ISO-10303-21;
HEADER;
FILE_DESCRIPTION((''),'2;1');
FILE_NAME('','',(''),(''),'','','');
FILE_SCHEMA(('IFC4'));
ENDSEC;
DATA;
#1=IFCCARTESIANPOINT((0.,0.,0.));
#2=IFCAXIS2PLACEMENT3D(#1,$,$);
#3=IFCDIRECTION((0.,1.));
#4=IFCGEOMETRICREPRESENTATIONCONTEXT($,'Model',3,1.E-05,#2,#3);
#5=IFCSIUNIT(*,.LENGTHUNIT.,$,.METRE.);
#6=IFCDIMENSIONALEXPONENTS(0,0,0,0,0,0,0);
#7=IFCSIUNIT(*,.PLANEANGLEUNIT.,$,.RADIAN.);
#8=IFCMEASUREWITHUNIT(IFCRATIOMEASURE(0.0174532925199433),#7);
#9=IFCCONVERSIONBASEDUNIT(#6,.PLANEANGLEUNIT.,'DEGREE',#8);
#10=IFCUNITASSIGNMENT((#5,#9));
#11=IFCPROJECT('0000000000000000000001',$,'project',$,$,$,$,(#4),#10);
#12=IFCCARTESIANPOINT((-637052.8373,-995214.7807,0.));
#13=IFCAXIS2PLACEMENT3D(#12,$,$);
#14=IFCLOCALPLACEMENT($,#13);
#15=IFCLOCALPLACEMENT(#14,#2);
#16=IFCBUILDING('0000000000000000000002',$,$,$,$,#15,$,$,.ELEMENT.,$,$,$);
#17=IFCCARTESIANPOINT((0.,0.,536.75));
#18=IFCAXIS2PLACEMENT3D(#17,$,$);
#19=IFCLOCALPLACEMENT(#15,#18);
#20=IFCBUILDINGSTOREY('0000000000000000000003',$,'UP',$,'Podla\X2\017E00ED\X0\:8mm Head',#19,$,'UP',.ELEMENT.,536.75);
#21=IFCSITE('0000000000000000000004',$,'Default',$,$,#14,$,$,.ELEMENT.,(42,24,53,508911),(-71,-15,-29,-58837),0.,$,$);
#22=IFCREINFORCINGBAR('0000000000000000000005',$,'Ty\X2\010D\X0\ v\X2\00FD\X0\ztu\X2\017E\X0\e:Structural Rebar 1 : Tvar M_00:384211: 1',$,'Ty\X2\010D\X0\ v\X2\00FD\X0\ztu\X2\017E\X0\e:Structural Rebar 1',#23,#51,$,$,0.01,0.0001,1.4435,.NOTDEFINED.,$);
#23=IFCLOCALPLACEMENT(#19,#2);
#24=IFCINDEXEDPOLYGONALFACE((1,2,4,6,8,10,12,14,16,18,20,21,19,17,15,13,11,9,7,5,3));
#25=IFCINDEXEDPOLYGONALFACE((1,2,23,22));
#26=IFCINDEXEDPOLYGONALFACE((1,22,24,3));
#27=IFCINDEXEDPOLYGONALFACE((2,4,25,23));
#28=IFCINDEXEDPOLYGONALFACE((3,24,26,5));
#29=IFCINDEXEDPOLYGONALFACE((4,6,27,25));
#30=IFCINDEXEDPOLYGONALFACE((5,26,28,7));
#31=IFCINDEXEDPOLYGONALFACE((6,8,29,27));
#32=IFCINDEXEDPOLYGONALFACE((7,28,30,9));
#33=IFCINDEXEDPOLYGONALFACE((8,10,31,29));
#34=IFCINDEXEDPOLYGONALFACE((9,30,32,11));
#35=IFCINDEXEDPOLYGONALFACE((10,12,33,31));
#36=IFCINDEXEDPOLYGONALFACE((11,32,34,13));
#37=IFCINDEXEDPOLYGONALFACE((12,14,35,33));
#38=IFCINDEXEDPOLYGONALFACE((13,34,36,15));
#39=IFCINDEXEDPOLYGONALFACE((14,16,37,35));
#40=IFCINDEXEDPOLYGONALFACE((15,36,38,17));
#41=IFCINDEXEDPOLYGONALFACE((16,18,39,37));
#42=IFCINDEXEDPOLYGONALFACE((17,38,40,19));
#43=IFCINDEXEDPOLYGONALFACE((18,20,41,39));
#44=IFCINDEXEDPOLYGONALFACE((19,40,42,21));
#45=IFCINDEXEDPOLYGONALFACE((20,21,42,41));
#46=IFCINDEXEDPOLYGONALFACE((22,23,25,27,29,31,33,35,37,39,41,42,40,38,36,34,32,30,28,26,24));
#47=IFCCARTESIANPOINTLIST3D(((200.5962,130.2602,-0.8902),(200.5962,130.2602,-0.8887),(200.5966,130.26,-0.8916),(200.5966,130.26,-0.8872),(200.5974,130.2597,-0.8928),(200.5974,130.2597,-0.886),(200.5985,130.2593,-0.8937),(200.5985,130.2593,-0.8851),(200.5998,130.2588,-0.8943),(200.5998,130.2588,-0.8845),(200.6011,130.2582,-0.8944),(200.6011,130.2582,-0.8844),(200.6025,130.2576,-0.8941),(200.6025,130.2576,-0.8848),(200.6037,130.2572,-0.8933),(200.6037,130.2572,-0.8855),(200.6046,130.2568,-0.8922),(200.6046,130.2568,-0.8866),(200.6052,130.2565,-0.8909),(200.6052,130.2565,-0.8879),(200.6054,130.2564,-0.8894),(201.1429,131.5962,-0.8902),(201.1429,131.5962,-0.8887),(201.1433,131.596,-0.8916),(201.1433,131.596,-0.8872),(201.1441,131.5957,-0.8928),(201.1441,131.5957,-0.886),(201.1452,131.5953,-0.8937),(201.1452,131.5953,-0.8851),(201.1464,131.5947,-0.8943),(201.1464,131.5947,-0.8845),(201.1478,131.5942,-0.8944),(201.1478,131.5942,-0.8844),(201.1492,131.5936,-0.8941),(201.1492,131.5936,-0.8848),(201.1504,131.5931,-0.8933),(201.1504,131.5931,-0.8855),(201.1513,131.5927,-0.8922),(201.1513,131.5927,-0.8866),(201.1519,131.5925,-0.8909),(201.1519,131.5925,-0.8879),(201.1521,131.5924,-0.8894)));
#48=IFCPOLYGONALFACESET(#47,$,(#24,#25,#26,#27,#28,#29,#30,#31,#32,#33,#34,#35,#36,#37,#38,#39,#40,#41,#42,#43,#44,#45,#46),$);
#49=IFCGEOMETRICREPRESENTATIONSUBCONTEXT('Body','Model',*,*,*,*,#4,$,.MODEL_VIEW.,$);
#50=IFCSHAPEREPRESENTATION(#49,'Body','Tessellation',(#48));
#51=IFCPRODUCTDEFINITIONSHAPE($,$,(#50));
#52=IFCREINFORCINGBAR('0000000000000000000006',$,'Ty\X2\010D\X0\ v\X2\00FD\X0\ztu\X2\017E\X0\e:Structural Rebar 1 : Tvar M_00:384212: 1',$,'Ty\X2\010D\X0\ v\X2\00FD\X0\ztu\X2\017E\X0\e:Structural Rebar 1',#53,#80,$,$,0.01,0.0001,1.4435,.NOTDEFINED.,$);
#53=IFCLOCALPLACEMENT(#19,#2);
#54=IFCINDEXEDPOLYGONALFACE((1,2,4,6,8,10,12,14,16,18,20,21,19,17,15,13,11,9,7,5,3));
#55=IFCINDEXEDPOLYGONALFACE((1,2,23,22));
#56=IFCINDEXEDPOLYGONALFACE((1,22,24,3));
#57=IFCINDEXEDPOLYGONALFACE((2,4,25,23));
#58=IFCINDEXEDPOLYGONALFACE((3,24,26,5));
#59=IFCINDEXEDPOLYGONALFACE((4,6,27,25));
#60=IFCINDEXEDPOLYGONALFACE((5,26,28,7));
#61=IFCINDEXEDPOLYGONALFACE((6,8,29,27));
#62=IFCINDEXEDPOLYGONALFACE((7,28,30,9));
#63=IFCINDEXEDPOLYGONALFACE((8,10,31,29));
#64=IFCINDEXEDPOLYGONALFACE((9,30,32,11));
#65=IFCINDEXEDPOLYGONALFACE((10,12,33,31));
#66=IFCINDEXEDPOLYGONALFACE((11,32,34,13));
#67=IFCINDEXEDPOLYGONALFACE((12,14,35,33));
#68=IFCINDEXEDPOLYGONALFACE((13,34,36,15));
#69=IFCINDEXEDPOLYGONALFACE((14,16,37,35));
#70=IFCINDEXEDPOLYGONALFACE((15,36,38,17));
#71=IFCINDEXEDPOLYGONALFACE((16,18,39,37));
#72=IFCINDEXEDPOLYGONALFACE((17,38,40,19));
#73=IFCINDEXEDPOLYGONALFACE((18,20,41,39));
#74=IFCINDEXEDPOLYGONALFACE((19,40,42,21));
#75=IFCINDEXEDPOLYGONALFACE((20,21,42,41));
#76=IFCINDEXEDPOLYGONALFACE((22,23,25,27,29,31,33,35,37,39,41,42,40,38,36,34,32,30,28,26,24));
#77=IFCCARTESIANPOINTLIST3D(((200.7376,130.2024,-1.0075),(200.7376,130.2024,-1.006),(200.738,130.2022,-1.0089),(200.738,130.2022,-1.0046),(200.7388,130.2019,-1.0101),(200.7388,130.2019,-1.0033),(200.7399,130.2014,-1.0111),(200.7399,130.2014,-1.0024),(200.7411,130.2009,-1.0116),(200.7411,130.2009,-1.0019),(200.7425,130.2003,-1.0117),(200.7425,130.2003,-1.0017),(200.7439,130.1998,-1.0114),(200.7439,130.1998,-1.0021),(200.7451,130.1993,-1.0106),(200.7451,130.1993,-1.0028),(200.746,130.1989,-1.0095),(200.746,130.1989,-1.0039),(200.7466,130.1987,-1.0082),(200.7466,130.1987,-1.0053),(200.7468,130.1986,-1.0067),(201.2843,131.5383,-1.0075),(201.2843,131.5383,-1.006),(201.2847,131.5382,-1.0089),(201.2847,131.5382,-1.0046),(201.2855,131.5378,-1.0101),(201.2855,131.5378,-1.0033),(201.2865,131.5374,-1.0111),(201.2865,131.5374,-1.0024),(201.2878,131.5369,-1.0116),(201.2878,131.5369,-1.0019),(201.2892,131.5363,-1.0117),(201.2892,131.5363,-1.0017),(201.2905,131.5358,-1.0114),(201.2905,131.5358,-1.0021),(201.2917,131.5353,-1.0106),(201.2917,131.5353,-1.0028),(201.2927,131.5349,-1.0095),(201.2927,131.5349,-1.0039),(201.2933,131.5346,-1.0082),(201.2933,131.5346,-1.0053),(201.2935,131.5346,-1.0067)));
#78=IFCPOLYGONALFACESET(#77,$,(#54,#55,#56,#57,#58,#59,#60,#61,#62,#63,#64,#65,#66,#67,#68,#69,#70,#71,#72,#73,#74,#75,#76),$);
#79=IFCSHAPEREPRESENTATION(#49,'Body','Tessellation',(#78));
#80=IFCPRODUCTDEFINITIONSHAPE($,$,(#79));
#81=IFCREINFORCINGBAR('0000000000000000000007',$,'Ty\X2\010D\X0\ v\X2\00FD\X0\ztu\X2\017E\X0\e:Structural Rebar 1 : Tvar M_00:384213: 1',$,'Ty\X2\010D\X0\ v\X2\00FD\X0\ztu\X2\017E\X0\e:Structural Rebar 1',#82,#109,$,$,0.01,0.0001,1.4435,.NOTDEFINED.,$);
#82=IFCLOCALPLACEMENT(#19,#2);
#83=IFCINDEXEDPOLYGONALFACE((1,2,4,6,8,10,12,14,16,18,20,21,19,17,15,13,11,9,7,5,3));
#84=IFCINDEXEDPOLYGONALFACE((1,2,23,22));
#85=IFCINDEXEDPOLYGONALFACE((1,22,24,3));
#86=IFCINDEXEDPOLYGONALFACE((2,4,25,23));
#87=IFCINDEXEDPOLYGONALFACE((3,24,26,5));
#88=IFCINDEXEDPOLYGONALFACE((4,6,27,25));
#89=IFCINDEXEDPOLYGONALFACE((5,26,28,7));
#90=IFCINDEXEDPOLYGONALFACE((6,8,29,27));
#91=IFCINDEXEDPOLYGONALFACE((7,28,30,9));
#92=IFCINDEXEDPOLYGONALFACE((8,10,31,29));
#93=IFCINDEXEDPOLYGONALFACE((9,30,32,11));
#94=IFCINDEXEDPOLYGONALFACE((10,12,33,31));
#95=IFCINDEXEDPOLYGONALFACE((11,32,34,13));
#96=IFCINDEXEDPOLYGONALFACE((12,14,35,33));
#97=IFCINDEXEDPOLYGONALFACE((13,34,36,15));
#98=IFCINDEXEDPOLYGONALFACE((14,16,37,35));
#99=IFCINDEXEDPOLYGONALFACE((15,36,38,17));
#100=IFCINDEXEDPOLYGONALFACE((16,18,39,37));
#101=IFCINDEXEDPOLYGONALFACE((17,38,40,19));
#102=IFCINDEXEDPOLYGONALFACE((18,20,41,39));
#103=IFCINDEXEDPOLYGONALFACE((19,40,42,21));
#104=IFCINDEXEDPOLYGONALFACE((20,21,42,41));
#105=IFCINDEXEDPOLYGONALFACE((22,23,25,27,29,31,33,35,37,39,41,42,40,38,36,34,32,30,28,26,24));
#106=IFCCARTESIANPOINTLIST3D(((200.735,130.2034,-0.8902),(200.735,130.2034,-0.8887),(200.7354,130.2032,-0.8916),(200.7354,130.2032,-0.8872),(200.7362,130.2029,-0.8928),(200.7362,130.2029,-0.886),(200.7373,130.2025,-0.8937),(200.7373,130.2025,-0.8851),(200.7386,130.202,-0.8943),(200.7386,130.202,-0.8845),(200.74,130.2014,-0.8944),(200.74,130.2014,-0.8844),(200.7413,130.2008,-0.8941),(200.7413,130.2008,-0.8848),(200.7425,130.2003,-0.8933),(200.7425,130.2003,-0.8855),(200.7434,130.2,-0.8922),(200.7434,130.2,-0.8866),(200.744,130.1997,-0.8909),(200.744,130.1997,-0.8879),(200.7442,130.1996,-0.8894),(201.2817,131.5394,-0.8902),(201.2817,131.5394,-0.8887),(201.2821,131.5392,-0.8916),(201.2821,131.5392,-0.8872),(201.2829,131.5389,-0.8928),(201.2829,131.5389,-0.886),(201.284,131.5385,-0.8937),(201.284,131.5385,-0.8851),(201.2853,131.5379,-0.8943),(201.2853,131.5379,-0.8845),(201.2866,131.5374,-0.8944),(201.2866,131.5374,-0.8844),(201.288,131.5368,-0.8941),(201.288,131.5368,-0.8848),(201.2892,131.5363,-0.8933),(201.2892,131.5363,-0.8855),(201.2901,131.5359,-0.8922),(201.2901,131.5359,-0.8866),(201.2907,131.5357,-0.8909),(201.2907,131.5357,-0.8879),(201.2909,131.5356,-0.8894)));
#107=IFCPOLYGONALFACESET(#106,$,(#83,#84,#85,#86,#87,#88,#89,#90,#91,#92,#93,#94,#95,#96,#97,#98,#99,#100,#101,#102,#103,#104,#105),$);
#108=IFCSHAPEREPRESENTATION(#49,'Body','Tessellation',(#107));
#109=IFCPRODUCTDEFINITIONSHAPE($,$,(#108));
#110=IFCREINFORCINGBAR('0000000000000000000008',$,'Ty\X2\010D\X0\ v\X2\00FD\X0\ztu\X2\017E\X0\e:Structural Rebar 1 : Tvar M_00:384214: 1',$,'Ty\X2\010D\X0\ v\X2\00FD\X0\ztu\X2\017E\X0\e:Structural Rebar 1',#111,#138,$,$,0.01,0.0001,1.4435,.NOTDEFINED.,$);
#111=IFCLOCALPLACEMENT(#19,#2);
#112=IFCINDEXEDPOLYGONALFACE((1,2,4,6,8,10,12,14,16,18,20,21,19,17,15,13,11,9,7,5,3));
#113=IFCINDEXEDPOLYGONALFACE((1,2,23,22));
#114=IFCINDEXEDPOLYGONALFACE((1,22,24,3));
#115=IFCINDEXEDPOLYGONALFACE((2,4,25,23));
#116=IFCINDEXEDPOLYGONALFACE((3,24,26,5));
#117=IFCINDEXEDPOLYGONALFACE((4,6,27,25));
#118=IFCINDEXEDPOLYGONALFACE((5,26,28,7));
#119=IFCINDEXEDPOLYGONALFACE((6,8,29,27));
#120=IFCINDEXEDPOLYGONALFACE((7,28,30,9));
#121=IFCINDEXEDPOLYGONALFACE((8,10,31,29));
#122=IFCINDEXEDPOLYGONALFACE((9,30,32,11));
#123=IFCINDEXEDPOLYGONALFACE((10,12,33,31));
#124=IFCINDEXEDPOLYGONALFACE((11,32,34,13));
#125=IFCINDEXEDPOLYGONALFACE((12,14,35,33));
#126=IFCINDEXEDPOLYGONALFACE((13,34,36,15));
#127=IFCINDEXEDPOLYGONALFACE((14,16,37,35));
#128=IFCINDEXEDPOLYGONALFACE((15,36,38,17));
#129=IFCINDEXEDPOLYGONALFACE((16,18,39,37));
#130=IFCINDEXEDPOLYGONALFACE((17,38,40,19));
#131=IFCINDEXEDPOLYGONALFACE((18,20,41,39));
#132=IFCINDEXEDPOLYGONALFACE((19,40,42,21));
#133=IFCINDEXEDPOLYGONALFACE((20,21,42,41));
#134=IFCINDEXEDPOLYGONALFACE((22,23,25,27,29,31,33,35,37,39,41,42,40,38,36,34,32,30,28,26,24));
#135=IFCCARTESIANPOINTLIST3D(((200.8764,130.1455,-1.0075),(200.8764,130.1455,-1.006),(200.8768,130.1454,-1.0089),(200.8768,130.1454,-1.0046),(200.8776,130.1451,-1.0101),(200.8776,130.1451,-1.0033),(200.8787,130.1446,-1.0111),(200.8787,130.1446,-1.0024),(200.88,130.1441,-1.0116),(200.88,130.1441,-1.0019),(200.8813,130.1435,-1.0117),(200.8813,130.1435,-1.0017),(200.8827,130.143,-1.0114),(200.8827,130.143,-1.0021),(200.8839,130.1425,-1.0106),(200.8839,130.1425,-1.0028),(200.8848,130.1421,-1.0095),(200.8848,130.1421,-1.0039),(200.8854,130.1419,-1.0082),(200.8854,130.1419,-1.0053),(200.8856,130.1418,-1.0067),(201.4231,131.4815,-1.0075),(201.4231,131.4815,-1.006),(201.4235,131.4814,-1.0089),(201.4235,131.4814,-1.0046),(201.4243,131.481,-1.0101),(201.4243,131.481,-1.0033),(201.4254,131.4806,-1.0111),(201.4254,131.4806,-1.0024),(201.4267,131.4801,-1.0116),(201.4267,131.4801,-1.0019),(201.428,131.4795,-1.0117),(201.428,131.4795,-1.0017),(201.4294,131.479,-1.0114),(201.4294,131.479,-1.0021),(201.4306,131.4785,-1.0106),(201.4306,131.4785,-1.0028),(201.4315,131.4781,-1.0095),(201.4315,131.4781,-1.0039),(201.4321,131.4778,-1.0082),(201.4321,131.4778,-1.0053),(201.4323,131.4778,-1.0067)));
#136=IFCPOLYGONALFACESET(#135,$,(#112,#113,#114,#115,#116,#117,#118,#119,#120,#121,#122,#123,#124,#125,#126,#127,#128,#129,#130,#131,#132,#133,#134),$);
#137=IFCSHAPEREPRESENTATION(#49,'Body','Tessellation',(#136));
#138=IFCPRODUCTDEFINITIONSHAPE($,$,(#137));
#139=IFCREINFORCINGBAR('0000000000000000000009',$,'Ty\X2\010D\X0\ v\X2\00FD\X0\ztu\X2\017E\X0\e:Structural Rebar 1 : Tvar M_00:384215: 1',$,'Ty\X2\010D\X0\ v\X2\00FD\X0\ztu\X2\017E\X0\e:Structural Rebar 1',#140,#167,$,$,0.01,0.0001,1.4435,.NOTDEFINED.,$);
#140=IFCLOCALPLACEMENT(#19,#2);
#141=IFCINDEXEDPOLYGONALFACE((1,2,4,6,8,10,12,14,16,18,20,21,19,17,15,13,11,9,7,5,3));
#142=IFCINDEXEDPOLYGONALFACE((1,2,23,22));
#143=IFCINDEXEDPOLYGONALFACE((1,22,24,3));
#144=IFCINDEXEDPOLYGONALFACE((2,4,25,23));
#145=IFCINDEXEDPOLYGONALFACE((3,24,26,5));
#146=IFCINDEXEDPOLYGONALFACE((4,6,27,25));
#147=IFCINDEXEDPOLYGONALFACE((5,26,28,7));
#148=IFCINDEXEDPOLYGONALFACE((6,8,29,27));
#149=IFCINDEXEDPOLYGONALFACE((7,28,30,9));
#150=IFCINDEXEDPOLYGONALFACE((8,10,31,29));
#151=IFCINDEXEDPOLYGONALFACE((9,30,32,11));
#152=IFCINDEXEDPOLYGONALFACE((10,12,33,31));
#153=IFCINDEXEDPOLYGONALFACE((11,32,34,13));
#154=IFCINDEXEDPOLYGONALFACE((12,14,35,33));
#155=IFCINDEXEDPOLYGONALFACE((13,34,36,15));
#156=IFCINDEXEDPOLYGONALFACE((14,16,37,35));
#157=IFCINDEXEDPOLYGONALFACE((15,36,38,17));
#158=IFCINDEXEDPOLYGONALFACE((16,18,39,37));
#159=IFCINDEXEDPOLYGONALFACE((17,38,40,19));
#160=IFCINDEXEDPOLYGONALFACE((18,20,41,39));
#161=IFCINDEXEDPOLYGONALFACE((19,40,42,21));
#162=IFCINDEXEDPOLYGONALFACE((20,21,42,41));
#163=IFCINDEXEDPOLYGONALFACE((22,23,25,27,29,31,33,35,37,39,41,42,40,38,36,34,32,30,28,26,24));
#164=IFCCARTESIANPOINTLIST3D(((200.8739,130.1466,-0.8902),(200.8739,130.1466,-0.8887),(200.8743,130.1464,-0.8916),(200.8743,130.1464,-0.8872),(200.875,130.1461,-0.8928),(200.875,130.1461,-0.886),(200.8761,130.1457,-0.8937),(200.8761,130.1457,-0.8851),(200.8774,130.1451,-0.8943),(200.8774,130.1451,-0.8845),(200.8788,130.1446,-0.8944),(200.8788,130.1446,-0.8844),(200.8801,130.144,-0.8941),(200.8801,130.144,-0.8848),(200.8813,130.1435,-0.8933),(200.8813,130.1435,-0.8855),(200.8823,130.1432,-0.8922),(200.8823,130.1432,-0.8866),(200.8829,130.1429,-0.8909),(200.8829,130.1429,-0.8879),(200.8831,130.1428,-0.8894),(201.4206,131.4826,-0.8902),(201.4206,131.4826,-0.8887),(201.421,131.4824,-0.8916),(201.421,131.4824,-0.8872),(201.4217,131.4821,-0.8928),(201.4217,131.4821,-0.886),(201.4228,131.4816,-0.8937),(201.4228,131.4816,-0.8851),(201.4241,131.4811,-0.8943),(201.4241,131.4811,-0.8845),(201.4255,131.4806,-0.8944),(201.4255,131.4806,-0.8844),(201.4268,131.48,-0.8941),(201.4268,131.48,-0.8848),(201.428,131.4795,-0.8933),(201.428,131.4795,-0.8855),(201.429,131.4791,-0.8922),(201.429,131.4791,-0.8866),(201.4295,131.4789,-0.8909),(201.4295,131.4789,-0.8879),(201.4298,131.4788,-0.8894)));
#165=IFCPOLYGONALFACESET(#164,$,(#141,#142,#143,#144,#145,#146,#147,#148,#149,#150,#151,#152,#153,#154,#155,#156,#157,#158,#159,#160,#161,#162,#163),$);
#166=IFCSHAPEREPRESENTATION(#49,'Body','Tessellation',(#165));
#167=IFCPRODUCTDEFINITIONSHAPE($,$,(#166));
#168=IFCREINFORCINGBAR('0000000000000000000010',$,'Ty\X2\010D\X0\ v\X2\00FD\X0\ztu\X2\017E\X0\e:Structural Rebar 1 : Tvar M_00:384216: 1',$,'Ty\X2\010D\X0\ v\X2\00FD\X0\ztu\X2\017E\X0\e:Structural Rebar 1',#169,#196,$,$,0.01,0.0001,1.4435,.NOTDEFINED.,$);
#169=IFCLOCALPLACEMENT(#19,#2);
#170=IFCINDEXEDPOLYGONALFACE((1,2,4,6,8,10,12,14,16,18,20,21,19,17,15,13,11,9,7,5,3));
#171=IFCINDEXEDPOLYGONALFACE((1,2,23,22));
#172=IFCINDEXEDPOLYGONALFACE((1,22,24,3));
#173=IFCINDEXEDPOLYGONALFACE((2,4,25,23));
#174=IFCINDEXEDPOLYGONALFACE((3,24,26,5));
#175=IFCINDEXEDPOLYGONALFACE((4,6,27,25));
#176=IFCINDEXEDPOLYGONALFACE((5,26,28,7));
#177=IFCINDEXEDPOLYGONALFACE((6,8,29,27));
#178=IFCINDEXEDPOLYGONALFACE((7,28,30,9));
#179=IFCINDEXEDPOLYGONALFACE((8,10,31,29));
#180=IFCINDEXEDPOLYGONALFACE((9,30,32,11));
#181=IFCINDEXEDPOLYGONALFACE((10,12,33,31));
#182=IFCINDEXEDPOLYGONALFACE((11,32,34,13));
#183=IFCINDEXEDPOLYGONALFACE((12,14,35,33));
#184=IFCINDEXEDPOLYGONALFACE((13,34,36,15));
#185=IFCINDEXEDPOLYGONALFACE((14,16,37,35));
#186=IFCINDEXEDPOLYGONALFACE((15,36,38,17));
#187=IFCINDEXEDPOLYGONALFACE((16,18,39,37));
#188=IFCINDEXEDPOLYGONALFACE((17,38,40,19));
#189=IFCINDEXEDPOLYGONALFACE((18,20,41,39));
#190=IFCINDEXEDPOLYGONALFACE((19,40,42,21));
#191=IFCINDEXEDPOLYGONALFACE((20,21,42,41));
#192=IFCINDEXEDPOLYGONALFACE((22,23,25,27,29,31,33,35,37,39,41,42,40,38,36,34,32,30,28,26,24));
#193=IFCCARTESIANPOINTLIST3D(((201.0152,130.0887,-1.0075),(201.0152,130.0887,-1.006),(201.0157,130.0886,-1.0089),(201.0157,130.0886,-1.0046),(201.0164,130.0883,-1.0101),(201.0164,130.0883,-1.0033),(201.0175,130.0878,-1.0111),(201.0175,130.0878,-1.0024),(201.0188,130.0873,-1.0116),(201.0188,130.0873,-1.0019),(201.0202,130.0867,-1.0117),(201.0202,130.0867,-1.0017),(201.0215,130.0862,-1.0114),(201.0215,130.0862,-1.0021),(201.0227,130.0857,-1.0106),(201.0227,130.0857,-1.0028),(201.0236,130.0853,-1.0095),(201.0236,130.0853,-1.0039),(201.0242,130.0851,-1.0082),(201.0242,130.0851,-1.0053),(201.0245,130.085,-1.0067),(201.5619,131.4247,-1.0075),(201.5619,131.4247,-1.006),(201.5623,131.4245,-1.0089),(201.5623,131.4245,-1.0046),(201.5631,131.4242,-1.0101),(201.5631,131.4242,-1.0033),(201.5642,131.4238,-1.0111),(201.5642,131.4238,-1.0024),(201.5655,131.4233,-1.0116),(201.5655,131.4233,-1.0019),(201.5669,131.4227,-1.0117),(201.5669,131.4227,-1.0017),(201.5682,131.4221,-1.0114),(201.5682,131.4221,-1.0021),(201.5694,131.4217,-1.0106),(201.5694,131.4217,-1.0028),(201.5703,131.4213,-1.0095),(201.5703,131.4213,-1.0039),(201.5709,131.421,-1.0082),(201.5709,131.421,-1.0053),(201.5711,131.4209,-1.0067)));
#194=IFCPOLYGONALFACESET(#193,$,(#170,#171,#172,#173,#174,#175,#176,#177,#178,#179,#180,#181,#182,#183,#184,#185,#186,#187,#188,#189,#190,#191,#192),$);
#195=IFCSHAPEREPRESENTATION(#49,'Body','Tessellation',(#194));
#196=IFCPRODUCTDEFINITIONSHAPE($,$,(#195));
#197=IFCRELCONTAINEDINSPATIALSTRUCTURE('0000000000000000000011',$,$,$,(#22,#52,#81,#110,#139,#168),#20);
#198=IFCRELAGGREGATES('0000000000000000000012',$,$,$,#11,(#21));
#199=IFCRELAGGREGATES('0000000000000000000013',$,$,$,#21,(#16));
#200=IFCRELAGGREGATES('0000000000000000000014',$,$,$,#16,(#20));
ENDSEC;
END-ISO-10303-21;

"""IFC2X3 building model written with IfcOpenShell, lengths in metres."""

from ifc_helpers import new_model, entity, si_unit, converted_unit, direction, frame, origin, place, context, subcontext, project, spatial, element, save


model = new_model("IFC2X3")

# Units and contexts
model_context = context("Model", 3, precision=1e-05, world=origin(), true_north=direction((0.0, 1.0)))
body_context = subcontext(model_context, "Body", "Model", "MODEL_VIEW")
ifc_project = project(units=[si_unit("LENGTHUNIT", "METRE"), converted_unit("PLANEANGLEUNIT", "DEGREE", entity("IfcRatioMeasure", 0.0174532925199433), si_unit("PLANEANGLEUNIT", "RADIAN"), dimensions=[0, 0, 0, 0, 0, 0, 0])], contexts=[model_context])

# Site, building, storey
site_placement = place(None, frame((-637052.8373, -995214.7807, 0.0)))
site = spatial("IfcSite", under=ifc_project, at=site_placement, Name="Default", CompositionType="ELEMENT", RefLatitude=(42, 24, 53, 508911), RefLongitude=(-71, -15, -29, -58837), RefElevation=0.0)
building_placement = place(site_placement, origin())
building = spatial("IfcBuilding", under=site, at=building_placement, CompositionType="ELEMENT")
storey_placement = place(building_placement, frame((0.0, 0.0, 536.75)))
storey = spatial("IfcBuildingStorey", under=building, at=storey_placement, Name="UP", ObjectType="Podlaží:8mm Head", LongName="UP", CompositionType="ELEMENT", Elevation=536.75)

# Reinforcing bars
reinforcing_bar_1_placement = place(storey_placement, origin())
element("IfcReinforcingBar", 1, at=reinforcing_bar_1_placement, inside=storey, Name="Tyč výztuže:Structural Rebar 1 : Tvar M_00:384211: 1", ObjectType="Tyč výztuže:Structural Rebar 1", BarLength=1.4435, BarRole="NOTDEFINED", CrossSectionArea=0.0001, NominalDiameter=0.01, context=body_context, shape_type="AdvancedSweptSolid", body=[
    entity("IfcSweptDiskSolid", entity("IfcCompositeCurve", [entity("IfcCompositeCurveSegment", "CONTINUOUS", True, entity("IfcPolyline", [entity("IfcCartesianPoint", [-201.1475, -131.5943, 0.8894]), entity("IfcCartesianPoint", [-200.6008, -130.2583, 0.8894])]))], False), 0.005, None, 0.0, 1.0),
])
reinforcing_bar_2_placement = place(storey_placement, origin())
element("IfcReinforcingBar", 2, at=reinforcing_bar_2_placement, inside=storey, Name="Tyč výztuže:Structural Rebar 1 : Tvar M_00:384212: 1", ObjectType="Tyč výztuže:Structural Rebar 1", BarLength=1.4435, BarRole="NOTDEFINED", CrossSectionArea=0.0001, NominalDiameter=0.01, context=body_context, shape_type="AdvancedSweptSolid", body=[
    entity("IfcSweptDiskSolid", entity("IfcCompositeCurve", [entity("IfcCompositeCurveSegment", "CONTINUOUS", True, entity("IfcPolyline", [entity("IfcCartesianPoint", [-201.2889, -131.5365, 1.0067]), entity("IfcCartesianPoint", [-200.7422, -130.2005, 1.0067])]))], False), 0.005, None, 0.0, 1.0),
])
reinforcing_bar_3_placement = place(storey_placement, origin())
element("IfcReinforcingBar", 3, at=reinforcing_bar_3_placement, inside=storey, Name="Tyč výztuže:Structural Rebar 1 : Tvar M_00:384213: 1", ObjectType="Tyč výztuže:Structural Rebar 1", BarLength=1.4435, BarRole="NOTDEFINED", CrossSectionArea=0.0001, NominalDiameter=0.01, context=body_context, shape_type="AdvancedSweptSolid", body=[
    entity("IfcSweptDiskSolid", entity("IfcCompositeCurve", [entity("IfcCompositeCurveSegment", "CONTINUOUS", True, entity("IfcPolyline", [entity("IfcCartesianPoint", [-201.2863, -131.5375, 0.8894]), entity("IfcCartesianPoint", [-200.7396, -130.2015, 0.8894])]))], False), 0.005, None, 0.0, 1.0),
])
reinforcing_bar_4_placement = place(storey_placement, origin())
element("IfcReinforcingBar", 4, at=reinforcing_bar_4_placement, inside=storey, Name="Tyč výztuže:Structural Rebar 1 : Tvar M_00:384214: 1", ObjectType="Tyč výztuže:Structural Rebar 1", BarLength=1.4435, BarRole="NOTDEFINED", CrossSectionArea=0.0001, NominalDiameter=0.01, context=body_context, shape_type="AdvancedSweptSolid", body=[
    entity("IfcSweptDiskSolid", entity("IfcCompositeCurve", [entity("IfcCompositeCurveSegment", "CONTINUOUS", True, entity("IfcPolyline", [entity("IfcCartesianPoint", [-201.4277, -131.4797, 1.0067]), entity("IfcCartesianPoint", [-200.881, -130.1437, 1.0067])]))], False), 0.005, None, 0.0, 1.0),
])
reinforcing_bar_5_placement = place(storey_placement, origin())
element("IfcReinforcingBar", 5, at=reinforcing_bar_5_placement, inside=storey, Name="Tyč výztuže:Structural Rebar 1 : Tvar M_00:384215: 1", ObjectType="Tyč výztuže:Structural Rebar 1", BarLength=1.4435, BarRole="NOTDEFINED", CrossSectionArea=0.0001, NominalDiameter=0.01, context=body_context, shape_type="AdvancedSweptSolid", body=[
    entity("IfcSweptDiskSolid", entity("IfcCompositeCurve", [entity("IfcCompositeCurveSegment", "CONTINUOUS", True, entity("IfcPolyline", [entity("IfcCartesianPoint", [-201.4251, -131.4807, 0.8894]), entity("IfcCartesianPoint", [-200.8784, -130.1447, 0.8894])]))], False), 0.005, None, 0.0, 1.0),
])
reinforcing_bar_6_placement = place(storey_placement, origin())
element("IfcReinforcingBar", 6, at=reinforcing_bar_6_placement, inside=storey, Name="Tyč výztuže:Structural Rebar 1 : Tvar M_00:384216: 1", ObjectType="Tyč výztuže:Structural Rebar 1", BarLength=1.4435, BarRole="NOTDEFINED", CrossSectionArea=0.0001, NominalDiameter=0.01, context=body_context, shape_type="AdvancedSweptSolid", body=[
    entity("IfcSweptDiskSolid", entity("IfcCompositeCurve", [entity("IfcCompositeCurveSegment", "CONTINUOUS", True, entity("IfcPolyline", [entity("IfcCartesianPoint", [-201.5665, -131.4228, 1.0067]), entity("IfcCartesianPoint", [-201.0198, -130.0869, 1.0067])]))], False), 0.005, None, 0.0, 1.0),
])

save(model, "model.ifc")
